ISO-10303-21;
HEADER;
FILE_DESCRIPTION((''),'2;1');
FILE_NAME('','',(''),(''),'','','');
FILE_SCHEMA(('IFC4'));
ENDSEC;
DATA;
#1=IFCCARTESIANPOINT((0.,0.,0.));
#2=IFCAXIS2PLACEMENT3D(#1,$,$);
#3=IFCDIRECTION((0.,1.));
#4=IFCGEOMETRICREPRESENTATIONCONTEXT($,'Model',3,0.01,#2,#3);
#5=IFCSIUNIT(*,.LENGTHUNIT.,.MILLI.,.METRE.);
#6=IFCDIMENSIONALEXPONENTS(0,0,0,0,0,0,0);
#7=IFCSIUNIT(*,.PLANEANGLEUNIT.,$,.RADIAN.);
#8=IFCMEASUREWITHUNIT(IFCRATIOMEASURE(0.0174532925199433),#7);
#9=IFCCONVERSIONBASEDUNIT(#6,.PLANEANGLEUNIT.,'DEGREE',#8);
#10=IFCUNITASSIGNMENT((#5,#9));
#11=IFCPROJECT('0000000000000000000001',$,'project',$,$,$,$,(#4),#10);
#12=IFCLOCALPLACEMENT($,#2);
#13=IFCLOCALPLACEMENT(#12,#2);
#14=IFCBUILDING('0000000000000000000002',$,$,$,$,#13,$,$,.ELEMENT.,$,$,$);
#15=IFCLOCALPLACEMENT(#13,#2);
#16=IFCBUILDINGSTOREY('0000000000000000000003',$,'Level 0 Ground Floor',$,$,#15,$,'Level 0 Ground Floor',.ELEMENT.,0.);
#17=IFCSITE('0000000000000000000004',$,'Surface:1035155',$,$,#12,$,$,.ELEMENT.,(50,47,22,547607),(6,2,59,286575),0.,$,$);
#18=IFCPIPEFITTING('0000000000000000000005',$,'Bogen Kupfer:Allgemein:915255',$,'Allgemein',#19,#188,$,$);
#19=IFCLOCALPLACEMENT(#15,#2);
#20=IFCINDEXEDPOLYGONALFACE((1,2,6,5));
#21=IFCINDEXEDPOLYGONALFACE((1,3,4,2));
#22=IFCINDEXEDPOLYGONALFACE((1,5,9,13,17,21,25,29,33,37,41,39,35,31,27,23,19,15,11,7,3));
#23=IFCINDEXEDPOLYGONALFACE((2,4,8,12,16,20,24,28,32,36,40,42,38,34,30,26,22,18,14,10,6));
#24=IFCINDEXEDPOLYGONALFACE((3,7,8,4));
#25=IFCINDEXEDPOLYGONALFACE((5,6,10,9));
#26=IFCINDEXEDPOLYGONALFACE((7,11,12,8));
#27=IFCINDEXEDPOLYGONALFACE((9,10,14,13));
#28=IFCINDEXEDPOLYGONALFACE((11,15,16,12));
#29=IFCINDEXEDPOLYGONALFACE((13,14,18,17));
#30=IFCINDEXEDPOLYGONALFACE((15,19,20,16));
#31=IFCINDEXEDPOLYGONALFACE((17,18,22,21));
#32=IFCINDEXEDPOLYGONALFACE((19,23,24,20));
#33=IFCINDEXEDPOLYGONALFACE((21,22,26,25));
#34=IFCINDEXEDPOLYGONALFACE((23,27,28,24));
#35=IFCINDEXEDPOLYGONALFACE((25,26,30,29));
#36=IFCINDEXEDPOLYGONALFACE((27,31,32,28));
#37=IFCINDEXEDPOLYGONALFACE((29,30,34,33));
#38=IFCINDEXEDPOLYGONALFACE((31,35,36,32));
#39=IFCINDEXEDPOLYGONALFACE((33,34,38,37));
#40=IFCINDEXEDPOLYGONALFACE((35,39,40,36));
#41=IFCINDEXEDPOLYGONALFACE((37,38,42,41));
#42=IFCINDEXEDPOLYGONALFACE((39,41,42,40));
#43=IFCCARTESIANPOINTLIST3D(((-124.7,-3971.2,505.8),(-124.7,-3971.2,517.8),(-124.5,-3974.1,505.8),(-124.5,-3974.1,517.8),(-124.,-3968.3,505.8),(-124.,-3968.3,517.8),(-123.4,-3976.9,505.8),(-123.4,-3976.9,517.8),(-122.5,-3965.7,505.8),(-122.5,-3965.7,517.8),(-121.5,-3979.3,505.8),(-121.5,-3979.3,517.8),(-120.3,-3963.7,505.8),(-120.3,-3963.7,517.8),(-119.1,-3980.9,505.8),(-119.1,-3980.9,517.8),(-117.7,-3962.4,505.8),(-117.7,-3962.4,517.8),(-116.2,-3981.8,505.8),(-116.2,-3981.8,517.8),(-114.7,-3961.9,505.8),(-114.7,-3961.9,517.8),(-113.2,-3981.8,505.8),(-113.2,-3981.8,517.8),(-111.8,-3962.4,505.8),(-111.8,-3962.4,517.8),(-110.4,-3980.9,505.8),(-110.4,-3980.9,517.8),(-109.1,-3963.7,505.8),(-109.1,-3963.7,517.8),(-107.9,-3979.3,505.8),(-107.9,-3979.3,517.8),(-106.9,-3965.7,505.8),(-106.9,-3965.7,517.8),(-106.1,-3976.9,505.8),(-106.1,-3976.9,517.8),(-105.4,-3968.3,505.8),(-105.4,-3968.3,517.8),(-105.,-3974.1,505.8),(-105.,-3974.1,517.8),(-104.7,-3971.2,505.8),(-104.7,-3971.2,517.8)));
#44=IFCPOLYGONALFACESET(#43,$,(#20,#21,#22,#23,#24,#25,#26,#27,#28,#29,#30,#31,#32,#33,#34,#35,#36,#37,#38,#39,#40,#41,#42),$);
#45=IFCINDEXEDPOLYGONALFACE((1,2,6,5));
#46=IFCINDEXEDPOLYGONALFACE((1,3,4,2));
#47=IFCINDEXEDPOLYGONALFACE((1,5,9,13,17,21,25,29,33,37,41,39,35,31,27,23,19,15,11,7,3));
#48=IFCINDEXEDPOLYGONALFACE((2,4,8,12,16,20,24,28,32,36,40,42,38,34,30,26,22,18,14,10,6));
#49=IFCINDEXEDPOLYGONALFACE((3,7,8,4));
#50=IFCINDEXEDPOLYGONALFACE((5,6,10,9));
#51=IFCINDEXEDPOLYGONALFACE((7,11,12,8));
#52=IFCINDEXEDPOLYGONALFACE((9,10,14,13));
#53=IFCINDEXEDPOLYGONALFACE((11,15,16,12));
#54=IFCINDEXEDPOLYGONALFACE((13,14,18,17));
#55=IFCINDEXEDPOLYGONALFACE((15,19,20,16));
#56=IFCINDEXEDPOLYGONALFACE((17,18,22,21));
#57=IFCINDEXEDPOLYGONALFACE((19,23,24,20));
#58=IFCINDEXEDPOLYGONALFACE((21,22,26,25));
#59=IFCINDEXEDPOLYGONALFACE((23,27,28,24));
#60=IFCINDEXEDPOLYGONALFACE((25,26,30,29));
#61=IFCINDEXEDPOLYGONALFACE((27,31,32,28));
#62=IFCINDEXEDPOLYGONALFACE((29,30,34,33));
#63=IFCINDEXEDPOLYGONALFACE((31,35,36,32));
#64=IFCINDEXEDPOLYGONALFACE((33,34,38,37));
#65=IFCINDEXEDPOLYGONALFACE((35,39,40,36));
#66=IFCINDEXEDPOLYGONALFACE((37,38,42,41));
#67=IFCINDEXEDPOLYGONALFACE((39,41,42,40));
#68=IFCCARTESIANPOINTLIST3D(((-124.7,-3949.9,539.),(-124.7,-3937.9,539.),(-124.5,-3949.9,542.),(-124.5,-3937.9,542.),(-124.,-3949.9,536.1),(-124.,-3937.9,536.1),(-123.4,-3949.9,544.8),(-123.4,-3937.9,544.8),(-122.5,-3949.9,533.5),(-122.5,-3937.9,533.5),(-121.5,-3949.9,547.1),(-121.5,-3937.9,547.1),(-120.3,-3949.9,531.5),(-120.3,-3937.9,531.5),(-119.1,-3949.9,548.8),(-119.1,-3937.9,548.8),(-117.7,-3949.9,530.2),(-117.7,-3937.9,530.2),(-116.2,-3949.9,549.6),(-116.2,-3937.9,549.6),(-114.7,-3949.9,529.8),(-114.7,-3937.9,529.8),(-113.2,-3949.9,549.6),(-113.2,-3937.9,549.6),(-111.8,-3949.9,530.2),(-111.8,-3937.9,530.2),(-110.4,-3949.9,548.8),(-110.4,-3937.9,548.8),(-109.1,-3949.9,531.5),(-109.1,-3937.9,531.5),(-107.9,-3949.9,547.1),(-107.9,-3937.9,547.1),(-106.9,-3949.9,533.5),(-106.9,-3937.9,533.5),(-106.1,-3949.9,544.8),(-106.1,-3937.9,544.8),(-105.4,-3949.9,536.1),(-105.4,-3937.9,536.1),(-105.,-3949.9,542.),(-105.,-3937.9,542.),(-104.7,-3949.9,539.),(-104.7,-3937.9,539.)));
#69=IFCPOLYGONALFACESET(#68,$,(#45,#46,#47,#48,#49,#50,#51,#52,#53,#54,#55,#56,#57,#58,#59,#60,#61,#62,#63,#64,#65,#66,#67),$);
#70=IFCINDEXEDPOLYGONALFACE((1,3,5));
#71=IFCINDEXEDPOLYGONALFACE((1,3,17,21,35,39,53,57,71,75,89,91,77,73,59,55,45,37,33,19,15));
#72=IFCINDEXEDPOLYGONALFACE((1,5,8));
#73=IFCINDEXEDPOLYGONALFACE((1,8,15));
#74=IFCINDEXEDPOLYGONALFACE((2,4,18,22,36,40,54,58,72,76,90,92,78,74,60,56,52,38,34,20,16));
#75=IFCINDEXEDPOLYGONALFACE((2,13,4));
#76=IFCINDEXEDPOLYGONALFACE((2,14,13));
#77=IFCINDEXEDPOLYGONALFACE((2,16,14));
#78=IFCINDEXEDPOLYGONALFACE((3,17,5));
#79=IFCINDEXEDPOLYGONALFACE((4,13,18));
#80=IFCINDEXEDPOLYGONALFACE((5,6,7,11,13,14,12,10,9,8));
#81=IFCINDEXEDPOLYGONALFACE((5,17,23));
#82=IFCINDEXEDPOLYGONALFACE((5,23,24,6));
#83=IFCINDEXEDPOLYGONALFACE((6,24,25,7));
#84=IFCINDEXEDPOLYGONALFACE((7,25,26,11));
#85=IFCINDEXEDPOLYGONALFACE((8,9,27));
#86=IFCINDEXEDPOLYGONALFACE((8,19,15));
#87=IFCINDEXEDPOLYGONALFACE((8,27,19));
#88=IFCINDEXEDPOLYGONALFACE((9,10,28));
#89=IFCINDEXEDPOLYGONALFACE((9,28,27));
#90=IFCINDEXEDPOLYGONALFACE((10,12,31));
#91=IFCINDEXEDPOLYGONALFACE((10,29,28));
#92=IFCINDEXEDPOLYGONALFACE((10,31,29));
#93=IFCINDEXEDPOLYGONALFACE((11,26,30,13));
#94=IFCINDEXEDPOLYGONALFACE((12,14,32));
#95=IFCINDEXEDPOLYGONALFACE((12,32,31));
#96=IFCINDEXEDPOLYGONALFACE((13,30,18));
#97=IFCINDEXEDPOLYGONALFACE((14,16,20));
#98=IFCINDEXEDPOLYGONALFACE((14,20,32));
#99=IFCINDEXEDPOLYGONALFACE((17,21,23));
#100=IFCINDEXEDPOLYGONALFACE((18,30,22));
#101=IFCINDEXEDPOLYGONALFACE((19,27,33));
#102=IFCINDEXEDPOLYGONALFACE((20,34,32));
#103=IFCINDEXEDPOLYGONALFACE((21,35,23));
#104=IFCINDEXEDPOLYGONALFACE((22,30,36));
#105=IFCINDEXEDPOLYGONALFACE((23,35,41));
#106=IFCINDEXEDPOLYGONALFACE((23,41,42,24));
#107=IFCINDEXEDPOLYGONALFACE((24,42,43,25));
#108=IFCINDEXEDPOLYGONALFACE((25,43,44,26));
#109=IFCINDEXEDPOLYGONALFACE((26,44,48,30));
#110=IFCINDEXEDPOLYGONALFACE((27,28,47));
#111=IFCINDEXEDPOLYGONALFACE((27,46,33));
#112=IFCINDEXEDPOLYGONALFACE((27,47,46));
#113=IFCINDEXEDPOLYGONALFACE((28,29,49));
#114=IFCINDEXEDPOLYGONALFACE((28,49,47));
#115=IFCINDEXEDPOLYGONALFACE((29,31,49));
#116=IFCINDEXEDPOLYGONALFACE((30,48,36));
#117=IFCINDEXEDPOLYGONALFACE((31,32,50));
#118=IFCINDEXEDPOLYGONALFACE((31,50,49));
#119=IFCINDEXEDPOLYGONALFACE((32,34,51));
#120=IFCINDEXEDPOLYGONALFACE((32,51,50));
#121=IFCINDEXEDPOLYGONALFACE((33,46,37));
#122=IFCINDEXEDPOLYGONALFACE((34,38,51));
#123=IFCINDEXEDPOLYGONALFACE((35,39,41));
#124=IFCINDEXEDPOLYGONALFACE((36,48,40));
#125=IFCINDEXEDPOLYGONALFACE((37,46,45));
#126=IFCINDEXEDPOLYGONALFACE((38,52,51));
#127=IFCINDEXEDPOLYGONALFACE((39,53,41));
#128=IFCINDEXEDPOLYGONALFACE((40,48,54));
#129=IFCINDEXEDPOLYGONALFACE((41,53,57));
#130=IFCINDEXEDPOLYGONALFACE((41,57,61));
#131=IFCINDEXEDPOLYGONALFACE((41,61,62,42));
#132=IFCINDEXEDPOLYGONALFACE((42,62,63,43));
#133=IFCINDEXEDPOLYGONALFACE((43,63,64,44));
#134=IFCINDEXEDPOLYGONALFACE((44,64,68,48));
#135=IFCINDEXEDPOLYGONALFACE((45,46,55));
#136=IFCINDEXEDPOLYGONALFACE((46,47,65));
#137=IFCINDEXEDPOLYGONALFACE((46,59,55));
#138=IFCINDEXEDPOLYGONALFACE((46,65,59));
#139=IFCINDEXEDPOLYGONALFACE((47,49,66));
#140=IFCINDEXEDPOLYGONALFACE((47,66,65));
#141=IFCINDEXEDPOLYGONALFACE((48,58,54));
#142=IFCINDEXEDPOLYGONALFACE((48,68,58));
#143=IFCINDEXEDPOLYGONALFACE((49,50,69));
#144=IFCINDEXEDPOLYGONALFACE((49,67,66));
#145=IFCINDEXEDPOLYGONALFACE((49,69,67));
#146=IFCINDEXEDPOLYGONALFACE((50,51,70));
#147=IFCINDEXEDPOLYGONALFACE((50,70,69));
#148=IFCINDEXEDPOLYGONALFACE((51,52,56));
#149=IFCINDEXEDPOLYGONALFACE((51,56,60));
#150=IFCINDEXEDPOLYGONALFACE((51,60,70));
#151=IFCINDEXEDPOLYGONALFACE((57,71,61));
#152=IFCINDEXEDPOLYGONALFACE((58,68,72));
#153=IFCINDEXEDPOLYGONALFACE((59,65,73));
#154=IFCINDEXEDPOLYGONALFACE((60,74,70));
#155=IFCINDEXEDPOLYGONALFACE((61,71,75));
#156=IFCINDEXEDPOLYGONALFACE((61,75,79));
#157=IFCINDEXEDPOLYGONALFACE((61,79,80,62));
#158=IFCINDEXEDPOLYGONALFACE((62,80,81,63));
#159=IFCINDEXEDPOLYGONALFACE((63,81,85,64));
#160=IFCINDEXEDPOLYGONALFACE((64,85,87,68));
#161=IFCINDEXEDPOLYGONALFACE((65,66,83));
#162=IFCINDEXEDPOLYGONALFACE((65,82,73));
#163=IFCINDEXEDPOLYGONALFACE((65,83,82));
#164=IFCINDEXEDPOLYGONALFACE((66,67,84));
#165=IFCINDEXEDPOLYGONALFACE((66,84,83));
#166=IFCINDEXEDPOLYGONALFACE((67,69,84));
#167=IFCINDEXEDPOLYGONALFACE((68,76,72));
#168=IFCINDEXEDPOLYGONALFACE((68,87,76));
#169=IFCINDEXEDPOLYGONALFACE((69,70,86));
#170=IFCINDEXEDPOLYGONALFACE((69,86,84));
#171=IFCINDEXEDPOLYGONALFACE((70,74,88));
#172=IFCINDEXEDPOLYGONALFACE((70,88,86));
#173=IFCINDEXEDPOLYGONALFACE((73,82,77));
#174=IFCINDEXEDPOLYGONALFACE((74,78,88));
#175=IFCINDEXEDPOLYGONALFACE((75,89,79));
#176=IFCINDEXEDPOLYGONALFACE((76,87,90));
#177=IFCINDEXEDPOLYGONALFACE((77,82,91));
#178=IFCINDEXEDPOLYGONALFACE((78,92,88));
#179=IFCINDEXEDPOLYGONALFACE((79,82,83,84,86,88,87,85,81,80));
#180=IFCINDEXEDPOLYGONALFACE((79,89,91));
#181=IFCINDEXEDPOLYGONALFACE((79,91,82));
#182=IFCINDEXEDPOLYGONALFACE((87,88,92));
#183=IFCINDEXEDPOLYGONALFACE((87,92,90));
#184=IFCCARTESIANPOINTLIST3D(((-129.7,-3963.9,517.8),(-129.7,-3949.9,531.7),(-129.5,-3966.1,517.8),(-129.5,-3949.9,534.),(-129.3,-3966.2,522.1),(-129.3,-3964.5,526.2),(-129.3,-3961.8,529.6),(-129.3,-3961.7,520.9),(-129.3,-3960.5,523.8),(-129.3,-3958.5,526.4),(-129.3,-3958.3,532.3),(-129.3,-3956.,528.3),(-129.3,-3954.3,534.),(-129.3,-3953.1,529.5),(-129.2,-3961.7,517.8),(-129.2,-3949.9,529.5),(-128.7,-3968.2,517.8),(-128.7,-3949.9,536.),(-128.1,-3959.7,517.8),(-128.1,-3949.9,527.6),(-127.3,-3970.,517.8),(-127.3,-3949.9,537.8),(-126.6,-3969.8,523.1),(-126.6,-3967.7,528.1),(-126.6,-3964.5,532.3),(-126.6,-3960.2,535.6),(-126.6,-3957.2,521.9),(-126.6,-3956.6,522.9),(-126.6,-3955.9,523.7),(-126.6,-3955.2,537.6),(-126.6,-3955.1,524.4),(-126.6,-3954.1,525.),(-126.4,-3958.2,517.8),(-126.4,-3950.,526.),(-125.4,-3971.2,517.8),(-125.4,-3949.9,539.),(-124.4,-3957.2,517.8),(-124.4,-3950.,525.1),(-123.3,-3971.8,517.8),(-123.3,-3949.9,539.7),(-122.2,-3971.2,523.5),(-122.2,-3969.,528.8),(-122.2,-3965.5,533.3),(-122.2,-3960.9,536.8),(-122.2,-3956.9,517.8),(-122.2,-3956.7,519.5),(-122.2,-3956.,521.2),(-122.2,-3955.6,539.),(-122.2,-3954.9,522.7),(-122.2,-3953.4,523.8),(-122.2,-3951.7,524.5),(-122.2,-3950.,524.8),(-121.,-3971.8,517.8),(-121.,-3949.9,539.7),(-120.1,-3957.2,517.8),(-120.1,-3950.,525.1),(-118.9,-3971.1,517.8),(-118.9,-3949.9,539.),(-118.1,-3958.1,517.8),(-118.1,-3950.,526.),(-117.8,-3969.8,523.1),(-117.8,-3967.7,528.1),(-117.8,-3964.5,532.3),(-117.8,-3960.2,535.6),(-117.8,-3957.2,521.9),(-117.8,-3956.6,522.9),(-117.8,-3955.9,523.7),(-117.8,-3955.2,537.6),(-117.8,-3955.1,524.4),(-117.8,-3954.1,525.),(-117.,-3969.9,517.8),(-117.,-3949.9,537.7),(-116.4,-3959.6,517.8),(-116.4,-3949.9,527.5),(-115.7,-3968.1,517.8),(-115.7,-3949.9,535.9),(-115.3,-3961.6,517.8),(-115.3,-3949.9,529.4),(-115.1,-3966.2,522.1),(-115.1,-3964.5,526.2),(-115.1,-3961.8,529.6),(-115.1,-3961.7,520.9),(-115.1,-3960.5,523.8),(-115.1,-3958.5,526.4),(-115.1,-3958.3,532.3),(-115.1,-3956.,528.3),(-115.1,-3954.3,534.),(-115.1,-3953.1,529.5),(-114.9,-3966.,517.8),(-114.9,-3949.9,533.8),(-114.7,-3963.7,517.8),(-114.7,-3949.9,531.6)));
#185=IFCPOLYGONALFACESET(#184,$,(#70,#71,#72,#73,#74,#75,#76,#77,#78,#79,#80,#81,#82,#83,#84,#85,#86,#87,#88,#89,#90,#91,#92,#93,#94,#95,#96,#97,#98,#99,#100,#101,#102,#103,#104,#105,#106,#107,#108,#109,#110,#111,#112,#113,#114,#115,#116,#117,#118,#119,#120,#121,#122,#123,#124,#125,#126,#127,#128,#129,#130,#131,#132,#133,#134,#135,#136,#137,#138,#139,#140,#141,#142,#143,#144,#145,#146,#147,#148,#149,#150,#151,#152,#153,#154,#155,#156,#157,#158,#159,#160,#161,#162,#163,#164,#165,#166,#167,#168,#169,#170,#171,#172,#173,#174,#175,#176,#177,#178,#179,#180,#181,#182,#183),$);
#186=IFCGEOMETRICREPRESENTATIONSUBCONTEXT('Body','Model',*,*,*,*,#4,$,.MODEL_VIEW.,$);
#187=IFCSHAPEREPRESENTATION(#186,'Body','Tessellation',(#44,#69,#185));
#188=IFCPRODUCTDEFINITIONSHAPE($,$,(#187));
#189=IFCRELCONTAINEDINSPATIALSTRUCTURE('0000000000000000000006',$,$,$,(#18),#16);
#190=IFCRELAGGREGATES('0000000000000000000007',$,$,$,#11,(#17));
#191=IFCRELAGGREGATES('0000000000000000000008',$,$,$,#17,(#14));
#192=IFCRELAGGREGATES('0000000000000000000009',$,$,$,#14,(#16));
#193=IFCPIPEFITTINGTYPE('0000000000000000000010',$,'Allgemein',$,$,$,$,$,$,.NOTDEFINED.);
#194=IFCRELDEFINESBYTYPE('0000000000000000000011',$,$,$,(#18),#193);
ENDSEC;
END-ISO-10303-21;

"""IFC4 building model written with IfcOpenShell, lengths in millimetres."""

from ifc_helpers import new_model, entity, si_unit, converted_unit, direction, frame, frame_2d, origin, place, context, subcontext, project, spatial, circle, extrude, source, transform, mapped, type_object, type_shapes, element, save


model = new_model("IFC4")

# Units and contexts
model_context = context("Model", 3, precision=0.01, world=origin(), true_north=direction((0.0, 1.0)))
body_context = subcontext(model_context, "Body", "Model", "MODEL_VIEW")
ifc_project = project(units=[si_unit("LENGTHUNIT", "METRE", prefix="MILLI"), converted_unit("PLANEANGLEUNIT", "DEGREE", entity("IfcRatioMeasure", 0.0174532925199433), si_unit("PLANEANGLEUNIT", "RADIAN"), dimensions=[0, 0, 0, 0, 0, 0, 0])], contexts=[model_context])

# Site, building, storey
site_placement = place(None, origin())
site = spatial("IfcSite", under=ifc_project, at=site_placement, Name="Surface:1035155", CompositionType="ELEMENT", RefLatitude=(50, 47, 22, 547607), RefLongitude=(6, 2, 59, 286575), RefElevation=0.0)
building_placement = place(site_placement, origin())
building = spatial("IfcBuilding", under=site, at=building_placement, CompositionType="ELEMENT")
storey_placement = place(building_placement, origin())
storey = spatial("IfcBuildingStorey", under=building, at=storey_placement, Name="Level 0 Ground Floor", LongName="Level 0 Ground Floor", CompositionType="ELEMENT", Elevation=0.0)

# Shared definitions
pipe_fitting_type = type_object("IfcPipeFittingType", Name="Allgemein", PredefinedType="NOTDEFINED")
ifc_direction = entity("IfcDirection", [0.0, 0.0, -1.0])
trimmed_curve = entity("IfcTrimmedCurve", entity("IfcCircle", entity("IfcAxis2Placement2D", entity("IfcCartesianPoint", [-14.5, 0.0]), entity("IfcDirection", [0.0, 1.0])), 14.5), [entity("IfcParameterValue", 270.0)], [entity("IfcParameterValue", 0.0)], True, "PARAMETER")
shared_shape_1 = source(origin(), body_context, "Body", "SolidModel", [
    extrude(circle(Radius=10.0, at=frame_2d((0.0, 0.0), x_axis=(1.0, 0.0))), frame((0.0, 22.0, 0.0), z_axis=(0.0, 1.0, 0.0), x_axis=(-1.0, 0.0, 0.0)), (0.0, 0.0, 1.0), 12.0),
    extrude(circle(Radius=10.0, at=frame_2d((0.0, 0.0), x_axis=(1.0, 0.0))), frame((-34.0, 0.0, 0.0), z_axis=(1.0, 0.0, 0.0), x_axis=(0.0, 1.0, 0.0)), (0.0, 0.0, 1.0), 12.0),
    entity("IfcSurfaceCurveSweptAreaSolid", entity("IfcCircleProfileDef", "AREA", None, entity("IfcAxis2Placement2D", entity("IfcCartesianPoint", [0.0, 7.5]), entity("IfcDirection", [1.0, 0.0])), 7.5), entity("IfcAxis2Placement3D", entity("IfcCartesianPoint", [-7.5, 22.0, 0.0]), ifc_direction, entity("IfcDirection", [1.0, 0.0, 0.0])), trimmed_curve, 0.0, 90.0, entity("IfcSurfaceOfLinearExtrusion", entity("IfcArbitraryOpenProfileDef", "CURVE", None, trimmed_curve), entity("IfcAxis2Placement3D", entity("IfcCartesianPoint", [0.0, 0.0, -304.8])), ifc_direction, 1.0)),
])
type_shapes(pipe_fitting_type, [shared_shape_1])

# Pipe fitting
for number, where, z_axis, x_axis, name in (
    (1, (-114.7, -3971.9, 539.8), (1.0, 0.0, 0.0), (0.0, -1.0, 0.0), "Bogen Kupfer:Allgemein:915255"),
):
    element("IfcPipeFitting", number, at=place(storey_placement, frame(where, z_axis=z_axis, x_axis=x_axis)), inside=storey, type_object=pipe_fitting_type, Name=name, ObjectType="Allgemein", context=body_context, shape_type="MappedRepresentation", body=[
        mapped(shared_shape_1, transform((0.0, 0.0, 0.0), scale=1.0)),
    ])

save(model, "model.ifc")
